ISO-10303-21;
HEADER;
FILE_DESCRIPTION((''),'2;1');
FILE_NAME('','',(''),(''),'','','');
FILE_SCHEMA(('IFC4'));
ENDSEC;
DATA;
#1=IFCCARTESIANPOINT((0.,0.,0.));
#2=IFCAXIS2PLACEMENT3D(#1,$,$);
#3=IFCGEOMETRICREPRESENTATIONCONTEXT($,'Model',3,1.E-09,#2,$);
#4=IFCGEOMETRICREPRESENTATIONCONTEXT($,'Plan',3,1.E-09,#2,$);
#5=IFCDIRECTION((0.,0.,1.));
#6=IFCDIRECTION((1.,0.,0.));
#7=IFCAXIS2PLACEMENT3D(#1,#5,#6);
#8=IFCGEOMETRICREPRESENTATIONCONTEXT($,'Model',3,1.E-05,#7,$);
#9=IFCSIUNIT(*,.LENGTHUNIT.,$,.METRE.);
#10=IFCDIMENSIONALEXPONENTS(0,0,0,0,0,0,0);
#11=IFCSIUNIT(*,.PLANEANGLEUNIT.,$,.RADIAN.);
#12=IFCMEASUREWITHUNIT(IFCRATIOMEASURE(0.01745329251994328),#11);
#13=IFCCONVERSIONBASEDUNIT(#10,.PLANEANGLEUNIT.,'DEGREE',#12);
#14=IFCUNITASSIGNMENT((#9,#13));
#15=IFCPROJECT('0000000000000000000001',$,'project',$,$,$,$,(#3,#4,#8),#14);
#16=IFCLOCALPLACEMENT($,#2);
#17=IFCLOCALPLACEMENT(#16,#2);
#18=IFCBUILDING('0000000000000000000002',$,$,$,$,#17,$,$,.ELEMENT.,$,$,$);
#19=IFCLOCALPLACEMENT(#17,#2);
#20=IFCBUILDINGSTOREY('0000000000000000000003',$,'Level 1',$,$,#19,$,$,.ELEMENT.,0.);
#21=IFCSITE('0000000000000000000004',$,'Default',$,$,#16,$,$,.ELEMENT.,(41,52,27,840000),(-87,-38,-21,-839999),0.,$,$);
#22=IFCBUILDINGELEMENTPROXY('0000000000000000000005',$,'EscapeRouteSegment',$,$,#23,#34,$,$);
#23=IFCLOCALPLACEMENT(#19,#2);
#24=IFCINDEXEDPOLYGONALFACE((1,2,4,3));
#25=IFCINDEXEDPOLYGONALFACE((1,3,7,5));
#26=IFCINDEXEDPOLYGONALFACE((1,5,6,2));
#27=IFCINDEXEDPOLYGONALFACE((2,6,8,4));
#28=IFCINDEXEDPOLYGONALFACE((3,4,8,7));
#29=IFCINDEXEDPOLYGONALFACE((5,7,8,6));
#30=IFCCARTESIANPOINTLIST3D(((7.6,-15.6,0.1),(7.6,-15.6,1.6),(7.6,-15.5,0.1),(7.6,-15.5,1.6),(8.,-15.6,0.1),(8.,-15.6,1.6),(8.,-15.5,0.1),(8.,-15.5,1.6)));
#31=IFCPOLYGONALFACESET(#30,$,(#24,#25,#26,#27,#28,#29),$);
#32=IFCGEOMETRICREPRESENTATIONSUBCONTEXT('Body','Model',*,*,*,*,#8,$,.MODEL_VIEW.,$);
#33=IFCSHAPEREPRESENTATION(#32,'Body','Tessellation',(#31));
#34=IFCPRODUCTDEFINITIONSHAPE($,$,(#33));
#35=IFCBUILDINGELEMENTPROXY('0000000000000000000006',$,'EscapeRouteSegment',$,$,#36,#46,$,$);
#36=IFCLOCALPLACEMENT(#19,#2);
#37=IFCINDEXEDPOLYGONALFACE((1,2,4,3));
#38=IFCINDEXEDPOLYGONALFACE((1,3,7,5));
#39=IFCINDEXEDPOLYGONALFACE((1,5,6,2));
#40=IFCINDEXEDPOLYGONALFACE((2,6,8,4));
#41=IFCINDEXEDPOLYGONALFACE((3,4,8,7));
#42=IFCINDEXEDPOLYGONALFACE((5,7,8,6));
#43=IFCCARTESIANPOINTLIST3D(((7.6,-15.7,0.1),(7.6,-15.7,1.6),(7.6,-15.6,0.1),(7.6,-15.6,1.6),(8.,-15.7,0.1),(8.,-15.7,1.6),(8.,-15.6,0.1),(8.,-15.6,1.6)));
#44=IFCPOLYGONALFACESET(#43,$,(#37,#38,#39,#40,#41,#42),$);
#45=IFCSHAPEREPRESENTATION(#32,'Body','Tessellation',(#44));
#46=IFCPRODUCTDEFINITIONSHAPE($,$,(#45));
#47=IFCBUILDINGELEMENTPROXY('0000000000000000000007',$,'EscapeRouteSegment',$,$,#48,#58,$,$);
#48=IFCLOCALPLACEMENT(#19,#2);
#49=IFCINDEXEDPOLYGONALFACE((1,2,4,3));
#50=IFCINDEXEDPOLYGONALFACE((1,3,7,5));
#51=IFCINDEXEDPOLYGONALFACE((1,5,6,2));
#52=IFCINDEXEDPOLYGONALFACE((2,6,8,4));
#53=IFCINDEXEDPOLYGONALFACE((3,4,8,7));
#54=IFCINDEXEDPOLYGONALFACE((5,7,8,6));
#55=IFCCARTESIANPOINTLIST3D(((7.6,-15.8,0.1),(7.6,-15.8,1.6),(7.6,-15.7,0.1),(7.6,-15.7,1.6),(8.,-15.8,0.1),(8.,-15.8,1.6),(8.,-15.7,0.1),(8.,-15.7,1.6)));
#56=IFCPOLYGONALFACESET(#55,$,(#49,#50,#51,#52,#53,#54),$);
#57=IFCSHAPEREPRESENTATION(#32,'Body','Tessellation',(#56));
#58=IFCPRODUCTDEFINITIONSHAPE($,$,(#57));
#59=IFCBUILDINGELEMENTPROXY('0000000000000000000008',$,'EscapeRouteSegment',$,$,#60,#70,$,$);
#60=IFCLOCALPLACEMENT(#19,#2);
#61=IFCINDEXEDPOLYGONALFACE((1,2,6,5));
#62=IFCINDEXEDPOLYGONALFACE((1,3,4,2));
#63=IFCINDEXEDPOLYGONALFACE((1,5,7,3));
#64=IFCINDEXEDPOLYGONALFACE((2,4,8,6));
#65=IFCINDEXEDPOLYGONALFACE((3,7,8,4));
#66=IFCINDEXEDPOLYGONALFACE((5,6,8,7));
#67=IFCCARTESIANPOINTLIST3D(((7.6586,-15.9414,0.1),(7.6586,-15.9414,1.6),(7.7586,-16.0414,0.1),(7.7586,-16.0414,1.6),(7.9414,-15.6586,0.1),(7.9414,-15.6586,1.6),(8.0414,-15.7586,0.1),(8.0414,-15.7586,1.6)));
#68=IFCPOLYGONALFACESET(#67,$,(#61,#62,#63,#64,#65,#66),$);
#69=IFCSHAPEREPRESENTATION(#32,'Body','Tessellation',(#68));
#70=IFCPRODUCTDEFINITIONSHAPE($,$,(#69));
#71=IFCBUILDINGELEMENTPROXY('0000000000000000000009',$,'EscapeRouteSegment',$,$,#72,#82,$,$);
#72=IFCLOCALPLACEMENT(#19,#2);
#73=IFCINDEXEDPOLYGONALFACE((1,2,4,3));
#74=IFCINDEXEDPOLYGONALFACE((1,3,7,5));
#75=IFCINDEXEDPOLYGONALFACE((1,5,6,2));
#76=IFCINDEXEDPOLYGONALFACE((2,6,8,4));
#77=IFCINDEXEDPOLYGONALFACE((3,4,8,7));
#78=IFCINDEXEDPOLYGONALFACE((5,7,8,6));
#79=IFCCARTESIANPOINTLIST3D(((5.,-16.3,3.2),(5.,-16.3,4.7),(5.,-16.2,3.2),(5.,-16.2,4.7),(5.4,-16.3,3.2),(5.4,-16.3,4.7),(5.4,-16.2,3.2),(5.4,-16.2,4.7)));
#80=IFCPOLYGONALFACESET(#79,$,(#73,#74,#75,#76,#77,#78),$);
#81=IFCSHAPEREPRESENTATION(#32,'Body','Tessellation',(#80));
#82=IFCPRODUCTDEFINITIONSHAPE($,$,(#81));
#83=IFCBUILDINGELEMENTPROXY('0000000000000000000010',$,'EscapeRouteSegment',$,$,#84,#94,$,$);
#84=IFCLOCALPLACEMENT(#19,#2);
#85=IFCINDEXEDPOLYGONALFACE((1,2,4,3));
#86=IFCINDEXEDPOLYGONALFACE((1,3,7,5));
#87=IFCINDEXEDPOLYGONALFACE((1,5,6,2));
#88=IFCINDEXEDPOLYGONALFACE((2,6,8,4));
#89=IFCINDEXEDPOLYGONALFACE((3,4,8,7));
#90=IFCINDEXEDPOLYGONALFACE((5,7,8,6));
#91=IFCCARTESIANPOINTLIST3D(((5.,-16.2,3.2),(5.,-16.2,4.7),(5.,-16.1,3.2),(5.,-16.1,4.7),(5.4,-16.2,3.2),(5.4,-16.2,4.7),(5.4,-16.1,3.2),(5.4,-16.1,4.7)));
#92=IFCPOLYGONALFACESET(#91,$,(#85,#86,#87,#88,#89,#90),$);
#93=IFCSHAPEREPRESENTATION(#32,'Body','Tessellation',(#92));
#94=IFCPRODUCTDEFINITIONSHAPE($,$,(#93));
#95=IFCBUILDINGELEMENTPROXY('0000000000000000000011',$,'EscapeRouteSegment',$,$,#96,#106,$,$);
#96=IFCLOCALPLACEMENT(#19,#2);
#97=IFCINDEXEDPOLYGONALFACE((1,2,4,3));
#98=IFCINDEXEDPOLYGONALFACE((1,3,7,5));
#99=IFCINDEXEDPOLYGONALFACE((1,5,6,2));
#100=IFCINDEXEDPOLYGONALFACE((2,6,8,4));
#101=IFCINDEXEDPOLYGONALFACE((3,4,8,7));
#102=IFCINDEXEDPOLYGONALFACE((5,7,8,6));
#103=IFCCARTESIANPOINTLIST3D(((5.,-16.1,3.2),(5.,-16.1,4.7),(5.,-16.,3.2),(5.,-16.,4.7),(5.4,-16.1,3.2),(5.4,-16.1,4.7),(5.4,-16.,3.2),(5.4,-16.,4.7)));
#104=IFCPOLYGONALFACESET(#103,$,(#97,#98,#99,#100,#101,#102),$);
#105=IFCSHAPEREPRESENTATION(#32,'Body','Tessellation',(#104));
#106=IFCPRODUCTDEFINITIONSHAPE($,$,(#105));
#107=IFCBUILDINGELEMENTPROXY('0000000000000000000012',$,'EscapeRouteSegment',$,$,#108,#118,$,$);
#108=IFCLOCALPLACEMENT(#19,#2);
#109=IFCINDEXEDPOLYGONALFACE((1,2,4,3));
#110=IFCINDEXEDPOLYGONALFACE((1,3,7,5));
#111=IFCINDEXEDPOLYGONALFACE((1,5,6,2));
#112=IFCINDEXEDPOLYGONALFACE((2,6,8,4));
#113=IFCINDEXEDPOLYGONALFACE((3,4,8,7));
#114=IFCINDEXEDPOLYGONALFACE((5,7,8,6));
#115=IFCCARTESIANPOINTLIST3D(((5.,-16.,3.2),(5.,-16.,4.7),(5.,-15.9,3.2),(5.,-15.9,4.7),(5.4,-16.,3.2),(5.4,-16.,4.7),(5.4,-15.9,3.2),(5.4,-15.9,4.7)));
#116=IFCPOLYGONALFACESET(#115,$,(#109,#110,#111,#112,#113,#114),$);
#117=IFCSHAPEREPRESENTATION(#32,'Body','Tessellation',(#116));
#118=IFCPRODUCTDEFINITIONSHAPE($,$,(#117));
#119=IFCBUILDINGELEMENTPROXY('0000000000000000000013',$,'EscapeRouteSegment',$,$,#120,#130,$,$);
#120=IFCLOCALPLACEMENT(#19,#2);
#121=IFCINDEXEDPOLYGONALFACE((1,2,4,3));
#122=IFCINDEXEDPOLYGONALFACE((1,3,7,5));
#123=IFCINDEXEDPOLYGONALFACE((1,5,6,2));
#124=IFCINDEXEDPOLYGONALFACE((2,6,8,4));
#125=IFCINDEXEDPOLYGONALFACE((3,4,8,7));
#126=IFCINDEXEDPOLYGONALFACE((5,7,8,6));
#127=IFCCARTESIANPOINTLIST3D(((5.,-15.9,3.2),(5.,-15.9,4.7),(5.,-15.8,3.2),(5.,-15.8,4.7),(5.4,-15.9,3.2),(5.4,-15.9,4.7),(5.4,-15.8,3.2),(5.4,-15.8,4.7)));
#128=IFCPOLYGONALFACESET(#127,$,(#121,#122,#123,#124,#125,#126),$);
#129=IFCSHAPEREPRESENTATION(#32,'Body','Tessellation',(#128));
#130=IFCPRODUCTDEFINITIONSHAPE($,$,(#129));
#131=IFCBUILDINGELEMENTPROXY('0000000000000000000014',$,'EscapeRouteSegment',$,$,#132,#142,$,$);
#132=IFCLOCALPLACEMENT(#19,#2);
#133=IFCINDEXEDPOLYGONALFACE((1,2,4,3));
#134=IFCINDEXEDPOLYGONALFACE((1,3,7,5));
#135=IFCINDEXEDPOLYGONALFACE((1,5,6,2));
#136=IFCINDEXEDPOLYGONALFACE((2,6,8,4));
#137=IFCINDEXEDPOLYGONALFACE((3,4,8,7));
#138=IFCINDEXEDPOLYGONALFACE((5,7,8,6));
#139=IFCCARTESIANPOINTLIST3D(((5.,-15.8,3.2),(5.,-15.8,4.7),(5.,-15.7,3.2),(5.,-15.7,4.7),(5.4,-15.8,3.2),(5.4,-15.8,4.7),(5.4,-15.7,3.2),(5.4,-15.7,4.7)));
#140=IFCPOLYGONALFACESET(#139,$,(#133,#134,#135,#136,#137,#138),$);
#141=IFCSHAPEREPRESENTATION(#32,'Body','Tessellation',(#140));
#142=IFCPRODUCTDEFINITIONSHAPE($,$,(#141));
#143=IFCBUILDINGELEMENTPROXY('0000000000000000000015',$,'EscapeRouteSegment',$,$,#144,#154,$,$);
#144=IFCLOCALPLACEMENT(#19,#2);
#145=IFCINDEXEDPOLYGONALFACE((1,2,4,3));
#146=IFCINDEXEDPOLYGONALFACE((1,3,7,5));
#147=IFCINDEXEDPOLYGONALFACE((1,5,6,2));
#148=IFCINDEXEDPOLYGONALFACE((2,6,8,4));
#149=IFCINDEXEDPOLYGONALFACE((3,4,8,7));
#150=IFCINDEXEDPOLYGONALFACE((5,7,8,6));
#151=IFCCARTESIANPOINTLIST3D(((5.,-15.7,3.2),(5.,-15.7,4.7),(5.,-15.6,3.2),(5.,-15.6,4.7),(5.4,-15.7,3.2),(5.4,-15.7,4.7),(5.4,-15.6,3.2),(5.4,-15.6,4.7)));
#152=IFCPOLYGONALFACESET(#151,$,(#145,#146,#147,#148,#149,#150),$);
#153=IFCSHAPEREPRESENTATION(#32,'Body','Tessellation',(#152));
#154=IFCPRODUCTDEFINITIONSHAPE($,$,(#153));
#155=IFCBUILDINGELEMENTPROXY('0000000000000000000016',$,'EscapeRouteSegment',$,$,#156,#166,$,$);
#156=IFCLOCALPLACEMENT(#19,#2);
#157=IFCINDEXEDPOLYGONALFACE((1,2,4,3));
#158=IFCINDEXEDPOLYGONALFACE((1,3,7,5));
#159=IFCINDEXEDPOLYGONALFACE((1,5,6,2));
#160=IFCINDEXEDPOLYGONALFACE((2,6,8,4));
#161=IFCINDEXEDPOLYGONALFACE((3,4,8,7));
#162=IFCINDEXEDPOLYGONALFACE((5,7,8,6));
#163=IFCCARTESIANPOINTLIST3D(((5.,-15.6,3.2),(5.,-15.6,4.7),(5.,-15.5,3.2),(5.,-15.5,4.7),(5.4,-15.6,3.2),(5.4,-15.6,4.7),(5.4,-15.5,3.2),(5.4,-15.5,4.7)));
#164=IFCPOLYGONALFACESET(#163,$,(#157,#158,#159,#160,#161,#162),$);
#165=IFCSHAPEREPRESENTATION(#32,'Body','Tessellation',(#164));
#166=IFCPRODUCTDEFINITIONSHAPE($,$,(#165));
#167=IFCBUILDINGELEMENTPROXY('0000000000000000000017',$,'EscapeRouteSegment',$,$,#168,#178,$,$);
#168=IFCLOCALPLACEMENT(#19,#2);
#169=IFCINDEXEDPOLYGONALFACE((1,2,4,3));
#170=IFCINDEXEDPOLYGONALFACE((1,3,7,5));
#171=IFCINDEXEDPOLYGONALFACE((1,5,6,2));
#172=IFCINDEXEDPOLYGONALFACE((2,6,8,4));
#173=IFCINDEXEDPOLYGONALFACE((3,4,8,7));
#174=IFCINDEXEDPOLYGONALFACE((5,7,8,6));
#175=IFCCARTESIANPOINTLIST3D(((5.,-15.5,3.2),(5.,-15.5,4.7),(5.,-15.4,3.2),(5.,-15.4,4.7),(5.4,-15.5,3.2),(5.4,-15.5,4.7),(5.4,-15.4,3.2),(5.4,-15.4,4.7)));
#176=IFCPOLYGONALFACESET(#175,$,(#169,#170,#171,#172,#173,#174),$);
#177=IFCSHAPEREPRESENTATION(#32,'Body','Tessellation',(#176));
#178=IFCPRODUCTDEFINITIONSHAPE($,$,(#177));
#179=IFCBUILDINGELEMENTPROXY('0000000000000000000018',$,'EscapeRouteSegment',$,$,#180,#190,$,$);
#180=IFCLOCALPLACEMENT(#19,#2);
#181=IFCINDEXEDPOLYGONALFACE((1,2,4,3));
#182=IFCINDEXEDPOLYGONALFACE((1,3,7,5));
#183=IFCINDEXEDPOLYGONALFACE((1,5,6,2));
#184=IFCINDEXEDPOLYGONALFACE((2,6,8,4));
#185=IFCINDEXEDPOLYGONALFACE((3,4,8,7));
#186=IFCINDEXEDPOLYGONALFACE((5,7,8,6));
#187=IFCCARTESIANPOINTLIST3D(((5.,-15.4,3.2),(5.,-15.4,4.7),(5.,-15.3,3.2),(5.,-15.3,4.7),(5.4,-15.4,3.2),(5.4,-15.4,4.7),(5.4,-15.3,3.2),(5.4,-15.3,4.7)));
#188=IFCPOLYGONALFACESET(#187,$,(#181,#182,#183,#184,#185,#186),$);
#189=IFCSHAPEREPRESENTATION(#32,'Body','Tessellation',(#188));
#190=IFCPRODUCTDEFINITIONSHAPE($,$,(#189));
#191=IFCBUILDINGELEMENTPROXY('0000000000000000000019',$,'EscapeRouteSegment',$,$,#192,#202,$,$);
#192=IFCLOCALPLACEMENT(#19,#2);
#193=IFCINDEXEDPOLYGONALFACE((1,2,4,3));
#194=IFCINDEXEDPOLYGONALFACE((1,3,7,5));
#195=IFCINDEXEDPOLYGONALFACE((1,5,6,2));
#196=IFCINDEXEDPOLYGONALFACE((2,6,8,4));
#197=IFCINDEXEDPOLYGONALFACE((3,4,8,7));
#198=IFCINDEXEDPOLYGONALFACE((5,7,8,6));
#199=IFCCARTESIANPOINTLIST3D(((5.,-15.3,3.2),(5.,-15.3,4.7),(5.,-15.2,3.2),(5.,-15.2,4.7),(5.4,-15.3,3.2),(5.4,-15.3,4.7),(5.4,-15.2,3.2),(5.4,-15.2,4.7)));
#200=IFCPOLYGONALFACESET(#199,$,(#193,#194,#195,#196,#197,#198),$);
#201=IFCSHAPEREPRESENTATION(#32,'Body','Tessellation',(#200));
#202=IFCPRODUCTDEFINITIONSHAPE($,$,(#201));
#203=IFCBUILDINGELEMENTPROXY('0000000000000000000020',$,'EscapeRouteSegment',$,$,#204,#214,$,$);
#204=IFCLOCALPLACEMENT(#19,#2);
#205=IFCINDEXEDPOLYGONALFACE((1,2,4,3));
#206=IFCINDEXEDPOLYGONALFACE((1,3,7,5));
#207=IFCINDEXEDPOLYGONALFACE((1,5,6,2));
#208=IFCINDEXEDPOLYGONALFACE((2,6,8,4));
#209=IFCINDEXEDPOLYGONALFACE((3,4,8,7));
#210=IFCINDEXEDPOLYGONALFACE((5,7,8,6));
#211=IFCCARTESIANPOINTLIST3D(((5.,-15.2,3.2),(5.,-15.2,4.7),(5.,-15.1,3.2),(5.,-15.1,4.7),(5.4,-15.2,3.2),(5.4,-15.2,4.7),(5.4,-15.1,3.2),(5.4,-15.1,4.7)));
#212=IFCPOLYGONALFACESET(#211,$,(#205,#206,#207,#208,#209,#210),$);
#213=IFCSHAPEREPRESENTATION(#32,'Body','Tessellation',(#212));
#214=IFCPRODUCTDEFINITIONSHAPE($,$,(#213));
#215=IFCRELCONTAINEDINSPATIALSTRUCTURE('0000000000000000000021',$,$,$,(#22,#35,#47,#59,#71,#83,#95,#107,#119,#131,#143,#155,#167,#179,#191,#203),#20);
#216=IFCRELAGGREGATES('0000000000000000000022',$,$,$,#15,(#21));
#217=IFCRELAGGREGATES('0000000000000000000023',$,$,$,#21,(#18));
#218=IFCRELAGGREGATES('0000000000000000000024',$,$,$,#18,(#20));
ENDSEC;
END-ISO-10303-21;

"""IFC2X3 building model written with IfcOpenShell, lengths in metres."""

from ifc_helpers import new_model, entity, si_unit, converted_unit, frame, origin, origin_with_axes, place, context, subcontext, project, spatial, polyline, outline, extrude, element, save


model = new_model("IFC2X3")

# Units and contexts
model_context_1 = context("Model", 3, precision=1e-09, world=origin())
plan_context = context("Plan", 3, precision=1e-09, world=origin())
model_context_2 = context("Model", 3, precision=1e-05, world=origin_with_axes())
body_context = subcontext(model_context_2, "Body", "Model", "MODEL_VIEW")
ifc_project = project(units=[si_unit("LENGTHUNIT", "METRE"), converted_unit("PLANEANGLEUNIT", "DEGREE", entity("IfcRatioMeasure", 0.01745329251994328), si_unit("PLANEANGLEUNIT", "RADIAN"), dimensions=[0, 0, 0, 0, 0, 0, 0])], contexts=[model_context_1, plan_context, model_context_2])

# Site, building, storey
site_placement = place(None, origin())
site = spatial("IfcSite", under=ifc_project, at=site_placement, Name="Default", CompositionType="ELEMENT", RefLatitude=(41, 52, 27, 840000), RefLongitude=(-87, -38, -21, -839999), RefElevation=0.0)
building_placement = place(site_placement, origin())
building = spatial("IfcBuilding", under=site, at=building_placement, CompositionType="ELEMENT")
storey_placement = place(building_placement, origin())
storey = spatial("IfcBuildingStorey", under=building, at=storey_placement, Name="Level 1", CompositionType="ELEMENT", Elevation=0.0)

# Building element proxies
proxy_1_placement = place(storey_placement, frame((7.8, -15.5, 0.1), z_axis=(0.0, 0.0, 1.0), x_axis=(0.0, -1.0, 0.0)))
element("IfcBuildingElementProxy", 1, at=proxy_1_placement, inside=storey, Name="EscapeRouteSegment", context=body_context, shape_type="SweptSolid", body=[
    extrude(outline(polyline([(0.0, -0.2), (0.0, 0.2), (0.1, 0.2), (0.1, -0.2), (0.0, -0.2)])), origin_with_axes(), (0.0, 0.0, 1.0), 1.5),
])
proxy_2_placement = place(storey_placement, frame((7.8, -15.6, 0.1), z_axis=(0.0, 0.0, 1.0), x_axis=(0.0, -1.0, 0.0)))
element("IfcBuildingElementProxy", 2, at=proxy_2_placement, inside=storey, Name="EscapeRouteSegment", context=body_context, shape_type="SweptSolid", body=[
    extrude(outline(polyline([(0.0, -0.2), (0.0, 0.2), (0.1, 0.2), (0.1, -0.2), (0.0, -0.2)])), origin_with_axes(), (0.0, 0.0, 1.0), 1.5),
])
proxy_3_placement = place(storey_placement, frame((7.8, -15.7, 0.1), z_axis=(0.0, 0.0, 1.0), x_axis=(0.0, -1.0, 0.0)))
element("IfcBuildingElementProxy", 3, at=proxy_3_placement, inside=storey, Name="EscapeRouteSegment", context=body_context, shape_type="SweptSolid", body=[
    extrude(outline(polyline([(0.0, -0.2), (0.0, 0.2), (0.1, 0.2), (0.1, -0.2), (0.0, -0.2)])), origin_with_axes(), (0.0, 0.0, 1.0), 1.5),
])
proxy_4_placement = place(storey_placement, frame((7.8, -15.8, 0.1), z_axis=(0.0, 0.0, 1.0), x_axis=(0.707108, -0.707105, 0.0)))
element("IfcBuildingElementProxy", 4, at=proxy_4_placement, inside=storey, Name="EscapeRouteSegment", context=body_context, shape_type="SweptSolid", body=[
    extrude(outline(polyline([(0.0, -0.2), (0.0, 0.2), (0.1414, 0.2), (0.1414, -0.2), (0.0, -0.2)])), origin_with_axes(), (0.0, 0.0, 1.0), 1.5),
])
proxy_5_placement = place(storey_placement, frame((5.2, -16.3, 3.2), z_axis=(0.0, 0.0, 1.0), x_axis=(0.0, 1.0, 0.0)))
element("IfcBuildingElementProxy", 5, at=proxy_5_placement, inside=storey, Name="EscapeRouteSegment", context=body_context, shape_type="SweptSolid", body=[
    extrude(outline(polyline([(0.0, -0.2), (0.0, 0.2), (0.1, 0.2), (0.1, -0.2), (0.0, -0.2)])), origin_with_axes(), (0.0, 0.0, 1.0), 1.5),
])
for number, where, z_axis, x_axis, name in (
    (6, (5.2, -16.2, 3.2), (0.0, 0.0, 1.0), (0.0, 1.0, 0.0), "EscapeRouteSegment"),
    (7, (5.2, -16.1, 3.2), (0.0, 0.0, 1.0), (0.0, 1.0, 0.0), "EscapeRouteSegment"),
    (8, (5.2, -16.0, 3.2), (0.0, 0.0, 1.0), (0.0, 1.0, 0.0), "EscapeRouteSegment"),
):
    element("IfcBuildingElementProxy", number, at=place(storey_placement, frame(where, z_axis=z_axis, x_axis=x_axis)), inside=storey, Name=name, context=body_context, shape_type="SweptSolid", body=[
        extrude(outline(polyline([(0.0, -0.2), (0.0, 0.2), (0.1, 0.2), (0.1, -0.2), (0.0, -0.2)])), origin_with_axes(), (0.0, 0.0, 1.0), 1.5),
    ])
proxy_6_placement = place(storey_placement, frame((5.2, -15.9, 3.2), z_axis=(0.0, 0.0, 1.0), x_axis=(0.0, 1.0, 0.0)))
element("IfcBuildingElementProxy", 9, at=proxy_6_placement, inside=storey, Name="EscapeRouteSegment", context=body_context, shape_type="SweptSolid", body=[
    extrude(outline(polyline([(0.0, -0.2), (0.0, 0.2), (0.1, 0.2), (0.1, -0.2), (0.0, -0.2)])), origin_with_axes(), (0.0, 0.0, 1.0), 1.5),
])
proxy_7_placement = place(storey_placement, frame((5.2, -15.8, 3.2), z_axis=(0.0, 0.0, 1.0), x_axis=(0.0, 1.0, 0.0)))
element("IfcBuildingElementProxy", 10, at=proxy_7_placement, inside=storey, Name="EscapeRouteSegment", context=body_context, shape_type="SweptSolid", body=[
    extrude(outline(polyline([(0.0, -0.2), (0.0, 0.2), (0.1, 0.2), (0.1, -0.2), (0.0, -0.2)])), origin_with_axes(), (0.0, 0.0, 1.0), 1.5),
])
proxy_8_placement = place(storey_placement, frame((5.2, -15.7, 3.2), z_axis=(0.0, 0.0, 1.0), x_axis=(0.0, 1.0, 0.0)))
element("IfcBuildingElementProxy", 11, at=proxy_8_placement, inside=storey, Name="EscapeRouteSegment", context=body_context, shape_type="SweptSolid", body=[
    extrude(outline(polyline([(0.0, -0.2), (0.0, 0.2), (0.1, 0.2), (0.1, -0.2), (0.0, -0.2)])), origin_with_axes(), (0.0, 0.0, 1.0), 1.5),
])
for number, where, z_axis, x_axis, name in (
    (12, (5.2, -15.6, 3.2), (0.0, 0.0, 1.0), (0.0, 1.0, 0.0), "EscapeRouteSegment"),
    (13, (5.2, -15.5, 3.2), (0.0, 0.0, 1.0), (0.0, 1.0, 0.0), "EscapeRouteSegment"),
):
    element("IfcBuildingElementProxy", number, at=place(storey_placement, frame(where, z_axis=z_axis, x_axis=x_axis)), inside=storey, Name=name, context=body_context, shape_type="SweptSolid", body=[
        extrude(outline(polyline([(0.0, -0.2), (0.0, 0.2), (0.1, 0.2), (0.1, -0.2), (0.0, -0.2)])), origin_with_axes(), (0.0, 0.0, 1.0), 1.5),
    ])
proxy_9_placement = place(storey_placement, frame((5.2, -15.4, 3.2), z_axis=(0.0, 0.0, 1.0), x_axis=(0.0, 1.0, 0.0)))
element("IfcBuildingElementProxy", 14, at=proxy_9_placement, inside=storey, Name="EscapeRouteSegment", context=body_context, shape_type="SweptSolid", body=[
    extrude(outline(polyline([(0.0, -0.2), (0.0, 0.2), (0.1, 0.2), (0.1, -0.2), (0.0, -0.2)])), origin_with_axes(), (0.0, 0.0, 1.0), 1.5),
])
proxy_10_placement = place(storey_placement, frame((5.2, -15.3, 3.2), z_axis=(0.0, 0.0, 1.0), x_axis=(0.0, 1.0, 0.0)))
element("IfcBuildingElementProxy", 15, at=proxy_10_placement, inside=storey, Name="EscapeRouteSegment", context=body_context, shape_type="SweptSolid", body=[
    extrude(outline(polyline([(0.0, -0.2), (0.0, 0.2), (0.1, 0.2), (0.1, -0.2), (0.0, -0.2)])), origin_with_axes(), (0.0, 0.0, 1.0), 1.5),
])
proxy_11_placement = place(storey_placement, frame((5.2, -15.2, 3.2), z_axis=(0.0, 0.0, 1.0), x_axis=(0.0, 1.0, 0.0)))
element("IfcBuildingElementProxy", 16, at=proxy_11_placement, inside=storey, Name="EscapeRouteSegment", context=body_context, shape_type="SweptSolid", body=[
    extrude(outline(polyline([(0.0, -0.2), (0.0, 0.2), (0.1, 0.2), (0.1, -0.2), (0.0, -0.2)])), origin_with_axes(), (0.0, 0.0, 1.0), 1.5),
])

save(model, "model.ifc")
